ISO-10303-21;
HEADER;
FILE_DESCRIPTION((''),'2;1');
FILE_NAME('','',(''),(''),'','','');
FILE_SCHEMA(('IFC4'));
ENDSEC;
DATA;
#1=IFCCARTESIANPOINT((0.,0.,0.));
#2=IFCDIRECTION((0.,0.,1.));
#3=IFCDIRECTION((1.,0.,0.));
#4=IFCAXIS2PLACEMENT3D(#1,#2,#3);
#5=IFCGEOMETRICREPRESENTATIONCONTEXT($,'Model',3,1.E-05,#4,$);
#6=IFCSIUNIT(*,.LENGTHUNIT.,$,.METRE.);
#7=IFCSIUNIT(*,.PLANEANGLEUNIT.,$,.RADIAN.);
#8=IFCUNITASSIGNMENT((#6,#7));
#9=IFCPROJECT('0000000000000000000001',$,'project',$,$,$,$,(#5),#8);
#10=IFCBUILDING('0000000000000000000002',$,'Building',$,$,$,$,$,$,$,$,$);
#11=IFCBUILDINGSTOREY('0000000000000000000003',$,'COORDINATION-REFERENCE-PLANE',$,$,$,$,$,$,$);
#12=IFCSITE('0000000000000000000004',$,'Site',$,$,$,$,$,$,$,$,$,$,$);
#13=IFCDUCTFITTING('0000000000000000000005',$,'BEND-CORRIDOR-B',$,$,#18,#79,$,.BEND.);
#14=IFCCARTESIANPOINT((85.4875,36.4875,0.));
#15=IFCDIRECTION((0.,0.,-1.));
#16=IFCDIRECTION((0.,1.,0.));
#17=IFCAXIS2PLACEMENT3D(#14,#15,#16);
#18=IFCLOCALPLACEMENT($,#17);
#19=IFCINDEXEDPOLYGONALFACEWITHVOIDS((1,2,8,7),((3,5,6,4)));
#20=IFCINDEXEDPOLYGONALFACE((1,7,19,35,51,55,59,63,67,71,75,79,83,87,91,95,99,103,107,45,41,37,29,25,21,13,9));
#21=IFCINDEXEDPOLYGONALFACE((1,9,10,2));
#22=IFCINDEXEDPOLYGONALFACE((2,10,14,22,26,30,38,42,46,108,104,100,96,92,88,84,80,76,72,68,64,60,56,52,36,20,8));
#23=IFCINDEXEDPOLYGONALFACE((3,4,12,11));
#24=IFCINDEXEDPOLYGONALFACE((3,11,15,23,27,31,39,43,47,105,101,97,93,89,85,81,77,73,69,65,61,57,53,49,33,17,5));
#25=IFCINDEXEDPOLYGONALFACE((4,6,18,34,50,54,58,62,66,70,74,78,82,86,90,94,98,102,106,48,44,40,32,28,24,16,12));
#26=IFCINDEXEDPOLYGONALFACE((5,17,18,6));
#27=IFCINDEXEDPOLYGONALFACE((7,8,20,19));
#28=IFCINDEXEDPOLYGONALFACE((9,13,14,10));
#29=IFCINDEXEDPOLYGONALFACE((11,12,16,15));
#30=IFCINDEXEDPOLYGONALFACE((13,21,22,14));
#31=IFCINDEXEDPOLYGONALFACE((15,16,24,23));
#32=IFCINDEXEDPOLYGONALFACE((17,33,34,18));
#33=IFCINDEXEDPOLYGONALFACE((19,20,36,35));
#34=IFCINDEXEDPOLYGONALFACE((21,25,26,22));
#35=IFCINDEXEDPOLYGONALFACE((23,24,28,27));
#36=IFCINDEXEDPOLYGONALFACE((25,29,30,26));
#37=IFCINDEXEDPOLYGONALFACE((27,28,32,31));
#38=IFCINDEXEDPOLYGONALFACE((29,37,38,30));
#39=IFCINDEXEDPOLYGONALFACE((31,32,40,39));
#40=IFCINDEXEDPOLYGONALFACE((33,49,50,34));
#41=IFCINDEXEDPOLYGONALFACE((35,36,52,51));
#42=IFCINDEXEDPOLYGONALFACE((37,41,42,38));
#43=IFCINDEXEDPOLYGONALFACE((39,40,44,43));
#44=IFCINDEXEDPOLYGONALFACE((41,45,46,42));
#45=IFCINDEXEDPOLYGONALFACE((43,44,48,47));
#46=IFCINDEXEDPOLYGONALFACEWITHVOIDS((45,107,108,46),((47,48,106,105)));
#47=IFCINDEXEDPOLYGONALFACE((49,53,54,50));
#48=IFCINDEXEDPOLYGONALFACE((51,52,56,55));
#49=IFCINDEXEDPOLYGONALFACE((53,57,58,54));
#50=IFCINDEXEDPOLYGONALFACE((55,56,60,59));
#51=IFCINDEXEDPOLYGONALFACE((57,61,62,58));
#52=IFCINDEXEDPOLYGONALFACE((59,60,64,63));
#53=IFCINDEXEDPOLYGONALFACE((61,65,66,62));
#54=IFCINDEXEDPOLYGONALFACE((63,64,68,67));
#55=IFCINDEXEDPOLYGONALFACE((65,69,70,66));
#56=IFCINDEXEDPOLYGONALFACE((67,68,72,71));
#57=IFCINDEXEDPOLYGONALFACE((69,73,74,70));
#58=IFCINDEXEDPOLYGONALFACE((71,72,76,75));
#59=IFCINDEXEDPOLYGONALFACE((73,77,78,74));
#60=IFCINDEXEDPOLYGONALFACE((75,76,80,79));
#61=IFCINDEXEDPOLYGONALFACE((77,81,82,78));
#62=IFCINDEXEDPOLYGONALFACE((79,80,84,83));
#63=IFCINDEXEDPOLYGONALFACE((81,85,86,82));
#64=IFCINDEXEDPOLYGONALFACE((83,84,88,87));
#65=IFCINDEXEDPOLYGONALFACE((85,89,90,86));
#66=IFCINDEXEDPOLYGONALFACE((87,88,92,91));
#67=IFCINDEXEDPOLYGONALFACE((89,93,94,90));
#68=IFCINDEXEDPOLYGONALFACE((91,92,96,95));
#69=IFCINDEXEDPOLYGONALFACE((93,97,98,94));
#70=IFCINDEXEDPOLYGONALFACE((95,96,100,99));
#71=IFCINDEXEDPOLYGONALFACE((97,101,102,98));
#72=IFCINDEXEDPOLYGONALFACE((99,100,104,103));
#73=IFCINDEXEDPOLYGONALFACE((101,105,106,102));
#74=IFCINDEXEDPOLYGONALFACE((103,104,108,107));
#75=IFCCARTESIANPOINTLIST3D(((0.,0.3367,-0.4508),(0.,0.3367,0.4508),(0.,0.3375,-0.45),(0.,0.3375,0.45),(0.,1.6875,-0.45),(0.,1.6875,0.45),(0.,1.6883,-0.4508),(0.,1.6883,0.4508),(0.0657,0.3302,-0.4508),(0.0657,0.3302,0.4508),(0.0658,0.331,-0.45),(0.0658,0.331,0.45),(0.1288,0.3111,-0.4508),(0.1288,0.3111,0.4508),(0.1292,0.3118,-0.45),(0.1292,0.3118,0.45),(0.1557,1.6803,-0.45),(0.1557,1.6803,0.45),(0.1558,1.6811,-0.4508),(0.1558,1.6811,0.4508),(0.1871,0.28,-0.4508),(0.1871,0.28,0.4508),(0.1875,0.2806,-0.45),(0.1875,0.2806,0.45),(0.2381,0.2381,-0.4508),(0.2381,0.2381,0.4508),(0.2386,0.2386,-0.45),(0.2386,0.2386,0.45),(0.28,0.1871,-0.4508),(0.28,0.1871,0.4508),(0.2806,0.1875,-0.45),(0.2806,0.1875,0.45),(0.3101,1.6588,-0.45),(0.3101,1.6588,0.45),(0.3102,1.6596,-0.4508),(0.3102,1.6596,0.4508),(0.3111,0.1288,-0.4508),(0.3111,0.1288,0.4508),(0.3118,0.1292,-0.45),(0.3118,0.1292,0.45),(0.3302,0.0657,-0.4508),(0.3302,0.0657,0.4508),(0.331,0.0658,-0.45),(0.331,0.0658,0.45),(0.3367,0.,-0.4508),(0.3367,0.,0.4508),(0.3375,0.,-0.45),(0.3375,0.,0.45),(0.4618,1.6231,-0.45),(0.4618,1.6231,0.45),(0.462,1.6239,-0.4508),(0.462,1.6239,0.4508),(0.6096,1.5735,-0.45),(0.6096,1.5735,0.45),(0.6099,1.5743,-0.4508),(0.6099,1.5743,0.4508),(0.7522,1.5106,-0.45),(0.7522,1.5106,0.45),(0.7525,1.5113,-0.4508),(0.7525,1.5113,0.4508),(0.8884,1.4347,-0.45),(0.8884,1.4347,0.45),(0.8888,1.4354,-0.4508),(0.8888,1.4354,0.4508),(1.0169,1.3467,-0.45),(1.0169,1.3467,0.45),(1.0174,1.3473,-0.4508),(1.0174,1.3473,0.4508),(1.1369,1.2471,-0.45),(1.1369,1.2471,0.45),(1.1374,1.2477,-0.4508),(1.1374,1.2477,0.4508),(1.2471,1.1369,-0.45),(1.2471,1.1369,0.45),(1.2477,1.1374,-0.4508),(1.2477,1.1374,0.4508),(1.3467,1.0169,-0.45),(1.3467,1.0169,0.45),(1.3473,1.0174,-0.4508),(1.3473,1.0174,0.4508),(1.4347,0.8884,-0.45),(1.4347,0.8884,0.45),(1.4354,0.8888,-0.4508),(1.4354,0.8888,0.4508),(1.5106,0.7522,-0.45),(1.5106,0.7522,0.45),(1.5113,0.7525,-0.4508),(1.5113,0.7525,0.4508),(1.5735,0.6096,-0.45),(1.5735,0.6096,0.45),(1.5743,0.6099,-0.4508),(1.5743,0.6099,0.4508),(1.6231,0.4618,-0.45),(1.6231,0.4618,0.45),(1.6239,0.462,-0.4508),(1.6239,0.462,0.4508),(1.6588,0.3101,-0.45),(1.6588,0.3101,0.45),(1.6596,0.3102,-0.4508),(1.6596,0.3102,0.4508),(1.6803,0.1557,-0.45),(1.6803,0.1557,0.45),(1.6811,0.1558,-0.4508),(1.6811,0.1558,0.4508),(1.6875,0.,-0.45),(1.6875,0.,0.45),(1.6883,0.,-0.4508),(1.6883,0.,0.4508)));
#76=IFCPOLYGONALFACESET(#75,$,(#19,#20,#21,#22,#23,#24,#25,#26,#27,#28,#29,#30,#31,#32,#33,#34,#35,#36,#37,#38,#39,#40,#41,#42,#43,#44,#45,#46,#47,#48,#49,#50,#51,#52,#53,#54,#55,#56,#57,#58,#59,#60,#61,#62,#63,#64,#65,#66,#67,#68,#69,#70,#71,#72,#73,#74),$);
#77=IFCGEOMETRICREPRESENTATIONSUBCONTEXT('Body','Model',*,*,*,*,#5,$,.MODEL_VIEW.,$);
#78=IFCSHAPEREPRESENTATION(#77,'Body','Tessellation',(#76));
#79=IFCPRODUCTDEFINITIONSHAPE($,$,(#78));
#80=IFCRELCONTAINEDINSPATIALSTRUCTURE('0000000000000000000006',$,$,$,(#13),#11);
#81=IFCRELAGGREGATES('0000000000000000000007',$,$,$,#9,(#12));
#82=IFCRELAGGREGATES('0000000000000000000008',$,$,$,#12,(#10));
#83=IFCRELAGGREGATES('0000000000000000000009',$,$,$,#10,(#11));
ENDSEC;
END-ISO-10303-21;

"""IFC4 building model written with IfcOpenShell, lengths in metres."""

from ifc_helpers import new_model, entity, si_unit, frame, origin_with_axes, place, context, subcontext, project, spatial, element, save


model = new_model("IFC4")

# Units and contexts
model_context = context("Model", 3, precision=1e-05, world=origin_with_axes())
body_context_1 = subcontext(model_context, "Body", "Model", "MODEL_VIEW")
ifc_project = project(units=[si_unit("LENGTHUNIT", "METRE"), si_unit("PLANEANGLEUNIT", "RADIAN")], contexts=[model_context])

# Site, building, storey
site = spatial("IfcSite", under=ifc_project, Name="Site")
building = spatial("IfcBuilding", under=site, Name="Building")
storey = spatial("IfcBuildingStorey", under=building, Name="COORDINATION-REFERENCE-PLANE")

# Duct fitting
duct_fitting_1_placement = place(None, frame((85.4875, 36.4875, 0.0), z_axis=(0.0, 0.0, -1.0), x_axis=(0.0, 1.0, 0.0)))
cartesian_point_1 = entity("IfcCartesianPoint", [0.0, 0.0, 0.0])
element("IfcDuctFitting", 1, at=duct_fitting_1_placement, inside=storey, Name="BEND-CORRIDOR-B", PredefinedType="BEND", context=body_context_1, shape_type="SweptSolid", body=[
    entity("IfcRevolvedAreaSolid", entity("IfcRectangleHollowProfileDef", "AREA", None, entity("IfcAxis2Placement2D", entity("IfcCartesianPoint", [1.0125, 0.0])), 1.3516, 0.9016, 0.0008), entity("IfcAxis2Placement3D", cartesian_point_1, entity("IfcDirection", [0.0, -1.0, 0.0]), entity("IfcDirection", [1.0, 0.0, 0.0])), entity("IfcAxis1Placement", cartesian_point_1, entity("IfcDirection", [0.0, 1.0, 0.0])), 1.570796),
])

save(model, "model.ifc")
